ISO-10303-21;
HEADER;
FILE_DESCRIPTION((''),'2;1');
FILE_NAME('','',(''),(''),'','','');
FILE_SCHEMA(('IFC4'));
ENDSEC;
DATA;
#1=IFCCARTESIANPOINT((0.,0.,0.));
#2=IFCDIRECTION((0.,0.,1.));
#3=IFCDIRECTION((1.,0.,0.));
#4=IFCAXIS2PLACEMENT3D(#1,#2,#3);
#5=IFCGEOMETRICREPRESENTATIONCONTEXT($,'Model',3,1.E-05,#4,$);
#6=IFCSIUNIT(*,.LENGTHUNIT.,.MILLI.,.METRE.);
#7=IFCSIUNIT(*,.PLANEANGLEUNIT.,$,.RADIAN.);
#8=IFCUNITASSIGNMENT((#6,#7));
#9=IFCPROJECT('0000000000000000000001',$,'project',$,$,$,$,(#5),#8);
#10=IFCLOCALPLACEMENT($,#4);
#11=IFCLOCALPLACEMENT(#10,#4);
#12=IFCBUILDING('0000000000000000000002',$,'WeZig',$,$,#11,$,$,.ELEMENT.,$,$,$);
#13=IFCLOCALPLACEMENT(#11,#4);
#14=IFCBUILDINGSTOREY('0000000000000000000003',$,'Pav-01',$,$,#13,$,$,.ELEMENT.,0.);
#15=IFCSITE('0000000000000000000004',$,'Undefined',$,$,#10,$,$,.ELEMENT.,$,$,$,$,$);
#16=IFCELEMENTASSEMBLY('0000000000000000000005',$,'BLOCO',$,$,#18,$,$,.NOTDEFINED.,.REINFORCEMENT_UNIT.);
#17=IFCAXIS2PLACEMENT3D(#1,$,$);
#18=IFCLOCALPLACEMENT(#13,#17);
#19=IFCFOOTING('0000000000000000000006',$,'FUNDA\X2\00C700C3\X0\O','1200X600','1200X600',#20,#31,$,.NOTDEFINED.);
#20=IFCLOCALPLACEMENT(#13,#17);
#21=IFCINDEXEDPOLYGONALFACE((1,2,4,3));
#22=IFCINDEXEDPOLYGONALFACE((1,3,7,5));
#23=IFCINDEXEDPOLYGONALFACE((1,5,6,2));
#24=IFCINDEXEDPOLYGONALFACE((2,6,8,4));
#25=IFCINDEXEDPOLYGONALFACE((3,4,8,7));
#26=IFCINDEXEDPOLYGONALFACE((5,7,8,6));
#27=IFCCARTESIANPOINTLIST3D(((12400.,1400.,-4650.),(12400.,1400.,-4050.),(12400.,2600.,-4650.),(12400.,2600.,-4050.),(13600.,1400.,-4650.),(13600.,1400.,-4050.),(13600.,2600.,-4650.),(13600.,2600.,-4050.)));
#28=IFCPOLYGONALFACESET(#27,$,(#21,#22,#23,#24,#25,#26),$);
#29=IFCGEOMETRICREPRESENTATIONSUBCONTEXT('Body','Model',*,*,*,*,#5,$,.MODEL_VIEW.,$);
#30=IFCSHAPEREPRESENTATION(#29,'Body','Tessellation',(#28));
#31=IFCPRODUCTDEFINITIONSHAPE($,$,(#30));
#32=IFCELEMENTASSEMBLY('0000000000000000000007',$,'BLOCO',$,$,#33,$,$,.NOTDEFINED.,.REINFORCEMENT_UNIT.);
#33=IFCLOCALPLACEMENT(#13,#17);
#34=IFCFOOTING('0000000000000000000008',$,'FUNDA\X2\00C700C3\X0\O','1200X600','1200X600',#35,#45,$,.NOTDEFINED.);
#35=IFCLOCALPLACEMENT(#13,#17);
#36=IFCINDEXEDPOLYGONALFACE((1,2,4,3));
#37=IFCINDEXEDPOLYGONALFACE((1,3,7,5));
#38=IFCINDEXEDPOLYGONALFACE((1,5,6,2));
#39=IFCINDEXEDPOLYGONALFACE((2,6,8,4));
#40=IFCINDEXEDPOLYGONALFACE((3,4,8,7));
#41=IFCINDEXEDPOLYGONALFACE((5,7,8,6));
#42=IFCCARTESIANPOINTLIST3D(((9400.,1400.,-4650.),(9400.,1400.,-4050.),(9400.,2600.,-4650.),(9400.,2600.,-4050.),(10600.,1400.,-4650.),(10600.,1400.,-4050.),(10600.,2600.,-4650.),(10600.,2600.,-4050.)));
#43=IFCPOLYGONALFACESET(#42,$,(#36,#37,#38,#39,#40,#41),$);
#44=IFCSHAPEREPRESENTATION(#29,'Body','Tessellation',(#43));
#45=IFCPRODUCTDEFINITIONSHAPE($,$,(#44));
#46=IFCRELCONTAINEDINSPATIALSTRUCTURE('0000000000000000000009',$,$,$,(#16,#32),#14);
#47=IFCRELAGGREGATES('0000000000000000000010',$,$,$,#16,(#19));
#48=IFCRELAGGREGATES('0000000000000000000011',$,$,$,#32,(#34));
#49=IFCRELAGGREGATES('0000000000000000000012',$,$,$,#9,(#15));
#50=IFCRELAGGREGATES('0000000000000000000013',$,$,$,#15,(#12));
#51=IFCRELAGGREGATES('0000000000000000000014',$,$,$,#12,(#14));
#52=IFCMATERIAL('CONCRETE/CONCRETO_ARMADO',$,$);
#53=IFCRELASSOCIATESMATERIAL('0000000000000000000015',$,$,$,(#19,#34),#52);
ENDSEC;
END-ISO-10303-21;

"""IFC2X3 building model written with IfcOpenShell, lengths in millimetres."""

from ifc_helpers import new_model, si_unit, frame, origin_with_axes, origin_2d_with_axis, place, context, subcontext, project, spatial, rectangle, extrude, material, element, aggregate, save


model = new_model("IFC2X3")

# Units and contexts
model_context = context("Model", 3, precision=1e-05, world=origin_with_axes())
body_context = subcontext(model_context, "Body", "Model", "MODEL_VIEW")
ifc_project = project(units=[si_unit("LENGTHUNIT", "METRE", prefix="MILLI"), si_unit("PLANEANGLEUNIT", "RADIAN")], contexts=[model_context])

# Site, building, storey
site_placement = place(None, origin_with_axes())
site = spatial("IfcSite", under=ifc_project, at=site_placement, Name="Undefined", CompositionType="ELEMENT")
building_placement = place(site_placement, origin_with_axes())
building = spatial("IfcBuilding", under=site, at=building_placement, Name="WeZig", CompositionType="ELEMENT")
storey_placement = place(building_placement, origin_with_axes())
storey = spatial("IfcBuildingStorey", under=building, at=storey_placement, Name="Pav-01", CompositionType="ELEMENT", Elevation=0.0)

# Element assemblies, footings
assembly_1_placement = place(storey_placement, origin_with_axes())
assembly_1 = element("IfcElementAssembly", 1, at=assembly_1_placement, inside=storey, Name="BLOCO", AssemblyPlace="NOTDEFINED", PredefinedType="REINFORCEMENT_UNIT")
ifc_material_1 = material(Name="CONCRETE/CONCRETO_ARMADO")
footing_1_placement = place(assembly_1_placement, frame((13000.0, 2000.0, -4650.0), z_axis=(0.0, 1.0, 0.0), x_axis=(0.0, 0.0, 1.0)))
footing_1 = element("IfcFooting", 2, at=footing_1_placement, material=ifc_material_1, Name="FUNDAÇÃO", Description="1200X600", ObjectType="1200X600", PredefinedType="NOTDEFINED", context=body_context, shape_type="SweptSolid", body=[
    extrude(rectangle(XDim=1200.0, YDim=1200.0, at=origin_2d_with_axis()), frame((600.0, 0.0, 0.0), z_axis=(-1.0, 0.0, 0.0), x_axis=(0.0, -1.0, 0.0)), (0.0, 0.0, 1.0), 600.0),
])
aggregate(assembly_1, [footing_1])
assembly_2_placement = place(storey_placement, origin_with_axes())
assembly_2 = element("IfcElementAssembly", 3, at=assembly_2_placement, inside=storey, Name="BLOCO", AssemblyPlace="NOTDEFINED", PredefinedType="REINFORCEMENT_UNIT")
footing_2_placement = place(assembly_2_placement, frame((10000.0, 2000.0, -4650.0), z_axis=(0.0, 1.0, 0.0), x_axis=(0.0, 0.0, 1.0)))
footing_2 = element("IfcFooting", 4, at=footing_2_placement, material=ifc_material_1, Name="FUNDAÇÃO", Description="1200X600", ObjectType="1200X600", PredefinedType="NOTDEFINED", context=body_context, shape_type="SweptSolid", body=[
    extrude(rectangle(XDim=1200.0, YDim=1200.0, at=origin_2d_with_axis()), frame((600.0, 0.0, 0.0), z_axis=(-1.0, 0.0, 0.0), x_axis=(0.0, -1.0, 0.0)), (0.0, 0.0, 1.0), 600.0),
])
aggregate(assembly_2, [footing_2])

save(model, "model.ifc")
